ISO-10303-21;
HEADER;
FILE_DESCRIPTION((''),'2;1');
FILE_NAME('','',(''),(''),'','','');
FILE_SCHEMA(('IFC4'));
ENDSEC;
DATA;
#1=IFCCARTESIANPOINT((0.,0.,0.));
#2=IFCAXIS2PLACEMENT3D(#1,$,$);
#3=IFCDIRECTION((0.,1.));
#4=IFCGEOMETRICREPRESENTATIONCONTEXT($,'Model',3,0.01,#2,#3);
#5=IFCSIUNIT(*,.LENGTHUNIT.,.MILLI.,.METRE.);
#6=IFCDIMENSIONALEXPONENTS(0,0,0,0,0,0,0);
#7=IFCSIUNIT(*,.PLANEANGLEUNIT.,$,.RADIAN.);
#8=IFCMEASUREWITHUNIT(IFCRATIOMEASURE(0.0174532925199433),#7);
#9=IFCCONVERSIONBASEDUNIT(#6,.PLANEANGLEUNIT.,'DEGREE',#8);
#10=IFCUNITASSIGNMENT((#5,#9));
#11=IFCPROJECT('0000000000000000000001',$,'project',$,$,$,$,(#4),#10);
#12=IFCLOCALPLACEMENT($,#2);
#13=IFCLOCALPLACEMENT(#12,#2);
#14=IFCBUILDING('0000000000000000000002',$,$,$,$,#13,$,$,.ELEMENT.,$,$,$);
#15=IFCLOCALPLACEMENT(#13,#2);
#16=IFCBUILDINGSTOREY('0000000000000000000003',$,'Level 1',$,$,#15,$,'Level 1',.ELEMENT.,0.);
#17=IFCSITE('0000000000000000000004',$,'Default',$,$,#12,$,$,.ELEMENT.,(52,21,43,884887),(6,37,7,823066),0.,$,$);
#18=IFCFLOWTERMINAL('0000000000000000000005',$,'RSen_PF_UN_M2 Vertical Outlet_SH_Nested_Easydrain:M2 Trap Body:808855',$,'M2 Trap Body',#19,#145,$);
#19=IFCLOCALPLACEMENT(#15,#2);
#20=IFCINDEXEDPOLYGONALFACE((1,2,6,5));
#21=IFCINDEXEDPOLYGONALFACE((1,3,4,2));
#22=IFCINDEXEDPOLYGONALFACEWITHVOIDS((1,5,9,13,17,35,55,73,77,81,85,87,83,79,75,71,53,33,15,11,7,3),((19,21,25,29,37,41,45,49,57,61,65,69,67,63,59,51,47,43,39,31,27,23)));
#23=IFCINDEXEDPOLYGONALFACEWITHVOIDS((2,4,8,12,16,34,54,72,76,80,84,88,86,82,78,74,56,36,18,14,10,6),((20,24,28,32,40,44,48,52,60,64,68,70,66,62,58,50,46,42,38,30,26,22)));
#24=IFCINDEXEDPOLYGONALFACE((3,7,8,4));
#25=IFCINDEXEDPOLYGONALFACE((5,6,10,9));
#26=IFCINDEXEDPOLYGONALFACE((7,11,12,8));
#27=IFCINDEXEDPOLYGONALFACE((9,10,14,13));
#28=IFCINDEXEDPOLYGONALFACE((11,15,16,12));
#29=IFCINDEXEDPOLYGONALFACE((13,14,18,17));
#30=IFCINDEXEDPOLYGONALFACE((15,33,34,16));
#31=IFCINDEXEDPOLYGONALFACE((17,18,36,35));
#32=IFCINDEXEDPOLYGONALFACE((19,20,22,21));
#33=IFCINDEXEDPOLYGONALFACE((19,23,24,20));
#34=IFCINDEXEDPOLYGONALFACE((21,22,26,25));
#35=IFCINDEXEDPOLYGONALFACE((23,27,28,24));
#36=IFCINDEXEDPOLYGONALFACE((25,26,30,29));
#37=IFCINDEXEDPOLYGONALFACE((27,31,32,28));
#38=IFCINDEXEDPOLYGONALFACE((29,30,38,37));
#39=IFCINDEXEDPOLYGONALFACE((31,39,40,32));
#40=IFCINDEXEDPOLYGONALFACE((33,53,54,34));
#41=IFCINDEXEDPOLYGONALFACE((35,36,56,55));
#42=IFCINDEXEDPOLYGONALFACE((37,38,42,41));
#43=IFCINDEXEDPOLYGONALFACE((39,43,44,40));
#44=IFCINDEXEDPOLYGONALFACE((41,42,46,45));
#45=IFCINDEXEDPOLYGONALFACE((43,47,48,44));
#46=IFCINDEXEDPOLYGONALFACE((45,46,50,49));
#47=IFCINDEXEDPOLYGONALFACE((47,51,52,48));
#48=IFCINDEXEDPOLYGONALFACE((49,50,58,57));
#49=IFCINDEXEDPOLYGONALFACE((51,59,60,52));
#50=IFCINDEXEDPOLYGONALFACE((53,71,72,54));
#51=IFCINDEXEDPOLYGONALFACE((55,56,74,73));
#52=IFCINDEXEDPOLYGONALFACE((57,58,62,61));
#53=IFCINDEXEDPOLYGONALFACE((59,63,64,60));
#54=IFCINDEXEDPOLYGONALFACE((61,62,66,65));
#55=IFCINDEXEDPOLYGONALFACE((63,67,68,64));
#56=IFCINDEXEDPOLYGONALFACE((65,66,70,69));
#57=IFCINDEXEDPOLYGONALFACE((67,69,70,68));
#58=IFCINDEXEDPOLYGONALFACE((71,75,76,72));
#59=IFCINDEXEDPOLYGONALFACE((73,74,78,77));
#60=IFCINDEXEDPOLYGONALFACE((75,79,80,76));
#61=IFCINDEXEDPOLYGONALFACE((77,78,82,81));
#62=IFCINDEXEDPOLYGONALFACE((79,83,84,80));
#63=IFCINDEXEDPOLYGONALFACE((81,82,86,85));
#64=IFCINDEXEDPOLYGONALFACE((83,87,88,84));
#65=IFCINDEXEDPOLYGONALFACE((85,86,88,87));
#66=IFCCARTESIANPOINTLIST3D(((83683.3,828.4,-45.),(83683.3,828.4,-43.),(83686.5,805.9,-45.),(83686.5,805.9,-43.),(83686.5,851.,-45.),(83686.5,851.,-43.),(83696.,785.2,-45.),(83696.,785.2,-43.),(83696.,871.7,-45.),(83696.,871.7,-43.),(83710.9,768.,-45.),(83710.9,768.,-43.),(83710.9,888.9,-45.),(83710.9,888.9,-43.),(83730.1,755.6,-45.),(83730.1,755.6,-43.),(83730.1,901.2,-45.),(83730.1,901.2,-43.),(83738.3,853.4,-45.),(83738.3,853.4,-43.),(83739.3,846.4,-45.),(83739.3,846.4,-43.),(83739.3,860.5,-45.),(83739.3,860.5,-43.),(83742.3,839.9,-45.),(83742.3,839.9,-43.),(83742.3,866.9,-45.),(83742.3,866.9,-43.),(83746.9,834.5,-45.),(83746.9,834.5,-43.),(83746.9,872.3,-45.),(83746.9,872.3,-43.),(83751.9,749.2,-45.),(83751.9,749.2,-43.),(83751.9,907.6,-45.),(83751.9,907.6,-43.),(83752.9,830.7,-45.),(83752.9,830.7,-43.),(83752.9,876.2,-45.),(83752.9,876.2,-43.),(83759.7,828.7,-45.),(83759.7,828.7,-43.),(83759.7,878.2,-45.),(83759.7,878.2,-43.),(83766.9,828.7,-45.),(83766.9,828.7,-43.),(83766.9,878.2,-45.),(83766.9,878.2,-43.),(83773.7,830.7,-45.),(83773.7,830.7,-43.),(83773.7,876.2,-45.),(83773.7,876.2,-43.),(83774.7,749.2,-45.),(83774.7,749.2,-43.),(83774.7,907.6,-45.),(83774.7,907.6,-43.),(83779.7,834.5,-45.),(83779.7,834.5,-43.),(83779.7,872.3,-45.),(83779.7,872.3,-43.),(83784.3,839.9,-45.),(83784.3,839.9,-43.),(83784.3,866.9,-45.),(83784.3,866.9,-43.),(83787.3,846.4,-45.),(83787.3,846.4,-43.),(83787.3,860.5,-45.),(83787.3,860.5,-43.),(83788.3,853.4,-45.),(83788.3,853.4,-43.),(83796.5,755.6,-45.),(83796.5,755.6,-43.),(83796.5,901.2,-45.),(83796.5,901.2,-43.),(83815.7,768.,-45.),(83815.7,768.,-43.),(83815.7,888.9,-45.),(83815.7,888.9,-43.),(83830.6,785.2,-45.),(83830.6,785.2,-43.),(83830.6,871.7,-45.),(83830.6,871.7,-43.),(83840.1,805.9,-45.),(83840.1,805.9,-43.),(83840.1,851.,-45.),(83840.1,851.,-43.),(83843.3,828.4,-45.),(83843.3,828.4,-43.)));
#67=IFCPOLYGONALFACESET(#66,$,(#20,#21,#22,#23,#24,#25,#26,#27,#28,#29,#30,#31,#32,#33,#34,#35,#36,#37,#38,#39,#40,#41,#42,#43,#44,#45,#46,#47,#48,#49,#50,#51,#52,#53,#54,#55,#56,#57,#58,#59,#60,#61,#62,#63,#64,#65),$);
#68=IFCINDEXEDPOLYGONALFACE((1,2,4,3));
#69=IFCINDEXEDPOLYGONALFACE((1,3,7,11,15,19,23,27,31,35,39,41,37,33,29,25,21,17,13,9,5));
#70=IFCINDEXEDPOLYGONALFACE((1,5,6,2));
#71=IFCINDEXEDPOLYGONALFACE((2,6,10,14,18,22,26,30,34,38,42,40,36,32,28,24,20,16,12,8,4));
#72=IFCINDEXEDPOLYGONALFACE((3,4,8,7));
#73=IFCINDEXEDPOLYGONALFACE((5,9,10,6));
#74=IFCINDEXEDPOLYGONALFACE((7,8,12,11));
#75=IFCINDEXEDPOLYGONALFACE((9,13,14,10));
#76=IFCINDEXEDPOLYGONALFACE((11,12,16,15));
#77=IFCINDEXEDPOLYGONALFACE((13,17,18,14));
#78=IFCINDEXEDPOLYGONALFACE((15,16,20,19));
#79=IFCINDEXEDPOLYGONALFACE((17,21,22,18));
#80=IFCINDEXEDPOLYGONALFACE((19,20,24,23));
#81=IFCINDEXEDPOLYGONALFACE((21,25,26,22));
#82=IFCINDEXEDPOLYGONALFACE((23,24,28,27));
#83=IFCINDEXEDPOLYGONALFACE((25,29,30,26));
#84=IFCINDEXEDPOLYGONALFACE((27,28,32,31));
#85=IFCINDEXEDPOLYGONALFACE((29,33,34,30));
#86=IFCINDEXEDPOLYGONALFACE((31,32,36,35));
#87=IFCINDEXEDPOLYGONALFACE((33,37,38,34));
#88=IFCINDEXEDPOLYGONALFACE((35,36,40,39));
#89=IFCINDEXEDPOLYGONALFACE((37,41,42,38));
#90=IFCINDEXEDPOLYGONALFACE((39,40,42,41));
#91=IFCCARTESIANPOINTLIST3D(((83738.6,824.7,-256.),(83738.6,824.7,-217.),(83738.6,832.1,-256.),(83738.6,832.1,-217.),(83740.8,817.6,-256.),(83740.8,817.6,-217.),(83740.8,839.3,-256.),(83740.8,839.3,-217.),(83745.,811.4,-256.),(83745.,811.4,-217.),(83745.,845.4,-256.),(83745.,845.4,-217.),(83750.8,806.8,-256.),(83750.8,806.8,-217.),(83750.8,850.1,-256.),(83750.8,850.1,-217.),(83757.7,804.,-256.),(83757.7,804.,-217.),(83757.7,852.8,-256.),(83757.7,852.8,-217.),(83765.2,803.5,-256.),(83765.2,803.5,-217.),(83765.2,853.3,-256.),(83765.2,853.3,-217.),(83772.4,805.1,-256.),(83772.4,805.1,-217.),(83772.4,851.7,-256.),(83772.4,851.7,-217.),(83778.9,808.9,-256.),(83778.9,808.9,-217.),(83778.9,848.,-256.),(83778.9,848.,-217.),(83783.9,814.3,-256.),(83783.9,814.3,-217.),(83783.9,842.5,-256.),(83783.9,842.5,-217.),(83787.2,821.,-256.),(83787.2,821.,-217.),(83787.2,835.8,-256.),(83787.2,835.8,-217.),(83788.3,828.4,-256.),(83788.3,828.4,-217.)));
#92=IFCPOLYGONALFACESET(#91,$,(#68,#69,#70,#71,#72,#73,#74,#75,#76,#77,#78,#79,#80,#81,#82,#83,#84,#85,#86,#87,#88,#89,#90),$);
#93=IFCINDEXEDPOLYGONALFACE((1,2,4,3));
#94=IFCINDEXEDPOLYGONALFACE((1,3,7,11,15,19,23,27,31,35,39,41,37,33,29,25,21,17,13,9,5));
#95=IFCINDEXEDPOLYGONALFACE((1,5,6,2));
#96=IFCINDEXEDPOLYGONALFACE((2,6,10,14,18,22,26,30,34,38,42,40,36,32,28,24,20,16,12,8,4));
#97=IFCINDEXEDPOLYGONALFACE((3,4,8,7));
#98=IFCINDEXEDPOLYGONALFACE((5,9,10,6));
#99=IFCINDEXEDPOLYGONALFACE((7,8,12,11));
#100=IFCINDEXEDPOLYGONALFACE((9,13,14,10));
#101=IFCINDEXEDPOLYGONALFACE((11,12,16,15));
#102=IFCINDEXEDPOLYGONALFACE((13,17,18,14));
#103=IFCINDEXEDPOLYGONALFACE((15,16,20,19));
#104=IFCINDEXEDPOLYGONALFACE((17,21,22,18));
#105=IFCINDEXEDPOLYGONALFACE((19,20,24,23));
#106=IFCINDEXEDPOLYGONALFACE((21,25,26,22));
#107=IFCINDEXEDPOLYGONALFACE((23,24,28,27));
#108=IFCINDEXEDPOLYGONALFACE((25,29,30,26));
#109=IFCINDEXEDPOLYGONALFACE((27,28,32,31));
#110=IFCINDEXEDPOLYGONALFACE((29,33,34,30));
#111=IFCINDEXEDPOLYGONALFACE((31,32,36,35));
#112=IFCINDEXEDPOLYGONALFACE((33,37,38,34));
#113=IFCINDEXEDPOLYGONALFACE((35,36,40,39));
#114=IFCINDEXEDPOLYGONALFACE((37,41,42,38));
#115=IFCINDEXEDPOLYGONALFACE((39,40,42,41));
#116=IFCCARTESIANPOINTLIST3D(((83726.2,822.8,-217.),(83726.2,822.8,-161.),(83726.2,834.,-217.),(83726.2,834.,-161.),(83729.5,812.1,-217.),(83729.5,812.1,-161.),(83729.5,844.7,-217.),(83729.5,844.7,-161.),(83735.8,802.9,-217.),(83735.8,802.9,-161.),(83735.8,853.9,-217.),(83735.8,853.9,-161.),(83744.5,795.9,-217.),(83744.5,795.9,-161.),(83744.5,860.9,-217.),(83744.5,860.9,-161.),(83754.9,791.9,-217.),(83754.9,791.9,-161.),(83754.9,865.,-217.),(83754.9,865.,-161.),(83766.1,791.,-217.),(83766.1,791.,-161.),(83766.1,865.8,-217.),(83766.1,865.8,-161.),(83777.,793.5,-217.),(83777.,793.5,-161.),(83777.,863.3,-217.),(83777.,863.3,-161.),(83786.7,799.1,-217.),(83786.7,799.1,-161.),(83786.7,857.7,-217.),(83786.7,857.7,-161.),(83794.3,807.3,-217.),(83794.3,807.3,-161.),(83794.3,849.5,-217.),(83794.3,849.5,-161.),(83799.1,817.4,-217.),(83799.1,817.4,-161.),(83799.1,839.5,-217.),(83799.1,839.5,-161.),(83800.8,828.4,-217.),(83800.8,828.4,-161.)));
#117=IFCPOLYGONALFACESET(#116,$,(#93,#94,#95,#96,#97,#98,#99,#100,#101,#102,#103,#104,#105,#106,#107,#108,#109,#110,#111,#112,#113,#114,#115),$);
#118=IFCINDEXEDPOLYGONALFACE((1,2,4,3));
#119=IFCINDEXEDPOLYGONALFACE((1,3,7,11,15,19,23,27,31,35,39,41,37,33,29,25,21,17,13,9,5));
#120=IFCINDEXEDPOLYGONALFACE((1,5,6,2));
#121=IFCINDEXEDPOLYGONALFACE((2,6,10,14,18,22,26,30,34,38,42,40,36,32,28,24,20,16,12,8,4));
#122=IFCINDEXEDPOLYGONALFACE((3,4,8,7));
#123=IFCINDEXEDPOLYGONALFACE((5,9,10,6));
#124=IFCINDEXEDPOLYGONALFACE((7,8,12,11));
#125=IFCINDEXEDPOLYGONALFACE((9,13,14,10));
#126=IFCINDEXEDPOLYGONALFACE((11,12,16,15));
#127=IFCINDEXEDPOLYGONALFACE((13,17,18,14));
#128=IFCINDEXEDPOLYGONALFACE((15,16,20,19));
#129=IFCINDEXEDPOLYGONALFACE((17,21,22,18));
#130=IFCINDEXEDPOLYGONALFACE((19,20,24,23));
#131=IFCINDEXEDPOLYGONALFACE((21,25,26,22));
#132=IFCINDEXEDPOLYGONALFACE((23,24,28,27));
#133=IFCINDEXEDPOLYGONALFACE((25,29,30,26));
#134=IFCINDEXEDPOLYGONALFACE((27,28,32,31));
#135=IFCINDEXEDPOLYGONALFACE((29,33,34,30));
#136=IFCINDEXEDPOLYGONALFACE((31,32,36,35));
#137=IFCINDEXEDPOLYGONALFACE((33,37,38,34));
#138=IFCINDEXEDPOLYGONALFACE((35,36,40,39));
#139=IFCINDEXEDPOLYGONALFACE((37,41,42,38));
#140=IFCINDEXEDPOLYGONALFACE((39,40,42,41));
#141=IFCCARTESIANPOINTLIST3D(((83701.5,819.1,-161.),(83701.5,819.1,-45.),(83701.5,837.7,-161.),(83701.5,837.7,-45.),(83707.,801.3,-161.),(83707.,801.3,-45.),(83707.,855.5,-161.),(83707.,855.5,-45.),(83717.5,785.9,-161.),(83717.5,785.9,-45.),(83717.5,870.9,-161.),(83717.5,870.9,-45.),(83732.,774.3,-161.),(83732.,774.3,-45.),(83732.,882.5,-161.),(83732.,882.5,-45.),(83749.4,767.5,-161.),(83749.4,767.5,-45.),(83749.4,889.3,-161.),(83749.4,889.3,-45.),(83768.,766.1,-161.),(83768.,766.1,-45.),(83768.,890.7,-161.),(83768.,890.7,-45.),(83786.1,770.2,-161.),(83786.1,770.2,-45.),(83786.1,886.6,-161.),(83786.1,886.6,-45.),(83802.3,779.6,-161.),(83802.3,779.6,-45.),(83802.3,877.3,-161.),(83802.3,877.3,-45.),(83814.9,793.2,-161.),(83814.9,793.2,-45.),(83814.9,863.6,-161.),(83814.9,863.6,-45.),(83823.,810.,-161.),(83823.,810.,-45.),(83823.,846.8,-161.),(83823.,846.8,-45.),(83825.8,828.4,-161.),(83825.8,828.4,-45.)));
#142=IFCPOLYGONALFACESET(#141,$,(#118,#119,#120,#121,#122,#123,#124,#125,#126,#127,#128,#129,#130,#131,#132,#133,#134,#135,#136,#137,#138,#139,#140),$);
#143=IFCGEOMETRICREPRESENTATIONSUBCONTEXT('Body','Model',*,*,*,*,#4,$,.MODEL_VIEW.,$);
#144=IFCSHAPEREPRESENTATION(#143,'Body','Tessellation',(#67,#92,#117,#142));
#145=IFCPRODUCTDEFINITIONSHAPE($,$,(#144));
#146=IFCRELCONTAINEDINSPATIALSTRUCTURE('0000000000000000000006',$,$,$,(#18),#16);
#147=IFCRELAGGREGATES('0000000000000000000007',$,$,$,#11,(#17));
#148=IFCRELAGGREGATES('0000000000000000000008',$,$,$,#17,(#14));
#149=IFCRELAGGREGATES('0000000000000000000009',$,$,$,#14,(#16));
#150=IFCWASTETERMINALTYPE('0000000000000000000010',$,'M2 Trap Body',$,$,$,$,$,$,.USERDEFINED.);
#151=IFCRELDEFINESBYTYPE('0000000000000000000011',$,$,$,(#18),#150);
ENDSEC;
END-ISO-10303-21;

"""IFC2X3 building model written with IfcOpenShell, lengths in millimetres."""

from ifc_helpers import new_model, entity, si_unit, converted_unit, direction, frame, frame_2d, origin, origin_2d_with_axis, place, context, subcontext, project, spatial, circle_curve, parameter, trimmed, segment, composite_curve, circle, outline, extrude, source, transform, mapped, type_object, type_shapes, element, save


model = new_model("IFC2X3")

# Units and contexts
model_context = context("Model", 3, precision=0.01, world=origin(), true_north=direction((0.0, 1.0)))
body_context = subcontext(model_context, "Body", "Model", "MODEL_VIEW")
ifc_project = project(units=[si_unit("LENGTHUNIT", "METRE", prefix="MILLI"), converted_unit("PLANEANGLEUNIT", "DEGREE", entity("IfcRatioMeasure", 0.0174532925199433), si_unit("PLANEANGLEUNIT", "RADIAN"), dimensions=[0, 0, 0, 0, 0, 0, 0])], contexts=[model_context])

# Site, building, storey
site_placement = place(None, origin())
site = spatial("IfcSite", under=ifc_project, at=site_placement, Name="Default", CompositionType="ELEMENT", RefLatitude=(52, 21, 43, 884887), RefLongitude=(6, 37, 7, 823066), RefElevation=0.0)
building_placement = place(site_placement, origin())
building = spatial("IfcBuilding", under=site, at=building_placement, CompositionType="ELEMENT")
storey_placement = place(building_placement, origin())
storey = spatial("IfcBuildingStorey", under=building, at=storey_placement, Name="Level 1", LongName="Level 1", CompositionType="ELEMENT", Elevation=0.0)

# Flow terminal
waste_terminal_type_1 = type_object("IfcWasteTerminalType", Name="M2 Trap Body", PredefinedType="USERDEFINED")
shared_shape_1 = source(origin(), body_context, "Body", "SweptSolid", [
    extrude(outline(composite_curve([segment(trimmed(circle_curve(origin_2d_with_axis(), 80.0), [parameter(0.0)], [parameter(180.0)], True, "PARAMETER"), True, "CONTINUOUS"), segment(trimmed(circle_curve(origin_2d_with_axis(), 80.0), [parameter(180.0)], [parameter(360.0)], True, "PARAMETER"), True, "CONTINUOUS")], self_intersect=False), holes=[composite_curve([segment(trimmed(circle_curve(frame_2d((0.0, 25.0), x_axis=(1.0, 0.0)), 25.0), [parameter(180.0)], [parameter(360.0)], True, "PARAMETER"), False, "CONTINUOUS"), segment(trimmed(circle_curve(frame_2d((0.0, 25.0), x_axis=(1.0, 0.0)), 25.0), [parameter(0.0)], [parameter(180.0)], True, "PARAMETER"), False, "CONTINUOUS")], self_intersect=False)]), frame((0.0, -25.0, -2.0)), (0.0, 0.0, 1.0), 2.0),
    extrude(circle(Radius=25.0, at=frame_2d((0.0, 0.0), x_axis=(1.0, 0.0))), frame((0.0, -25.0, -213.0)), (0.0, 0.0, 1.0), 39.0),
    extrude(circle(Radius=37.5, at=frame_2d((0.0, 0.0), x_axis=(1.0, 0.0))), frame((0.0, -25.0, -174.0)), (0.0, 0.0, 1.0), 56.0),
    extrude(circle(Radius=62.5, at=frame_2d((0.0, 0.0), x_axis=(1.0, 0.0))), frame((0.0, -25.0, -118.0)), (0.0, 0.0, 1.0), 116.0),
])
type_shapes(waste_terminal_type_1, [shared_shape_1])
for number, where, name in (
    (1, (83763.3, 853.4, -43.0), "RSen_PF_UN_M2 Vertical Outlet_SH_Nested_Easydrain:M2 Trap Body:808855"),
):
    element("IfcFlowTerminal", number, at=place(storey_placement, frame(where)), inside=storey, type_object=waste_terminal_type_1, Name=name, ObjectType="M2 Trap Body", context=body_context, shape_type="MappedRepresentation", body=[
        mapped(shared_shape_1, transform((0.0, 0.0, 0.0), scale=1.0)),
    ])

save(model, "model.ifc")
